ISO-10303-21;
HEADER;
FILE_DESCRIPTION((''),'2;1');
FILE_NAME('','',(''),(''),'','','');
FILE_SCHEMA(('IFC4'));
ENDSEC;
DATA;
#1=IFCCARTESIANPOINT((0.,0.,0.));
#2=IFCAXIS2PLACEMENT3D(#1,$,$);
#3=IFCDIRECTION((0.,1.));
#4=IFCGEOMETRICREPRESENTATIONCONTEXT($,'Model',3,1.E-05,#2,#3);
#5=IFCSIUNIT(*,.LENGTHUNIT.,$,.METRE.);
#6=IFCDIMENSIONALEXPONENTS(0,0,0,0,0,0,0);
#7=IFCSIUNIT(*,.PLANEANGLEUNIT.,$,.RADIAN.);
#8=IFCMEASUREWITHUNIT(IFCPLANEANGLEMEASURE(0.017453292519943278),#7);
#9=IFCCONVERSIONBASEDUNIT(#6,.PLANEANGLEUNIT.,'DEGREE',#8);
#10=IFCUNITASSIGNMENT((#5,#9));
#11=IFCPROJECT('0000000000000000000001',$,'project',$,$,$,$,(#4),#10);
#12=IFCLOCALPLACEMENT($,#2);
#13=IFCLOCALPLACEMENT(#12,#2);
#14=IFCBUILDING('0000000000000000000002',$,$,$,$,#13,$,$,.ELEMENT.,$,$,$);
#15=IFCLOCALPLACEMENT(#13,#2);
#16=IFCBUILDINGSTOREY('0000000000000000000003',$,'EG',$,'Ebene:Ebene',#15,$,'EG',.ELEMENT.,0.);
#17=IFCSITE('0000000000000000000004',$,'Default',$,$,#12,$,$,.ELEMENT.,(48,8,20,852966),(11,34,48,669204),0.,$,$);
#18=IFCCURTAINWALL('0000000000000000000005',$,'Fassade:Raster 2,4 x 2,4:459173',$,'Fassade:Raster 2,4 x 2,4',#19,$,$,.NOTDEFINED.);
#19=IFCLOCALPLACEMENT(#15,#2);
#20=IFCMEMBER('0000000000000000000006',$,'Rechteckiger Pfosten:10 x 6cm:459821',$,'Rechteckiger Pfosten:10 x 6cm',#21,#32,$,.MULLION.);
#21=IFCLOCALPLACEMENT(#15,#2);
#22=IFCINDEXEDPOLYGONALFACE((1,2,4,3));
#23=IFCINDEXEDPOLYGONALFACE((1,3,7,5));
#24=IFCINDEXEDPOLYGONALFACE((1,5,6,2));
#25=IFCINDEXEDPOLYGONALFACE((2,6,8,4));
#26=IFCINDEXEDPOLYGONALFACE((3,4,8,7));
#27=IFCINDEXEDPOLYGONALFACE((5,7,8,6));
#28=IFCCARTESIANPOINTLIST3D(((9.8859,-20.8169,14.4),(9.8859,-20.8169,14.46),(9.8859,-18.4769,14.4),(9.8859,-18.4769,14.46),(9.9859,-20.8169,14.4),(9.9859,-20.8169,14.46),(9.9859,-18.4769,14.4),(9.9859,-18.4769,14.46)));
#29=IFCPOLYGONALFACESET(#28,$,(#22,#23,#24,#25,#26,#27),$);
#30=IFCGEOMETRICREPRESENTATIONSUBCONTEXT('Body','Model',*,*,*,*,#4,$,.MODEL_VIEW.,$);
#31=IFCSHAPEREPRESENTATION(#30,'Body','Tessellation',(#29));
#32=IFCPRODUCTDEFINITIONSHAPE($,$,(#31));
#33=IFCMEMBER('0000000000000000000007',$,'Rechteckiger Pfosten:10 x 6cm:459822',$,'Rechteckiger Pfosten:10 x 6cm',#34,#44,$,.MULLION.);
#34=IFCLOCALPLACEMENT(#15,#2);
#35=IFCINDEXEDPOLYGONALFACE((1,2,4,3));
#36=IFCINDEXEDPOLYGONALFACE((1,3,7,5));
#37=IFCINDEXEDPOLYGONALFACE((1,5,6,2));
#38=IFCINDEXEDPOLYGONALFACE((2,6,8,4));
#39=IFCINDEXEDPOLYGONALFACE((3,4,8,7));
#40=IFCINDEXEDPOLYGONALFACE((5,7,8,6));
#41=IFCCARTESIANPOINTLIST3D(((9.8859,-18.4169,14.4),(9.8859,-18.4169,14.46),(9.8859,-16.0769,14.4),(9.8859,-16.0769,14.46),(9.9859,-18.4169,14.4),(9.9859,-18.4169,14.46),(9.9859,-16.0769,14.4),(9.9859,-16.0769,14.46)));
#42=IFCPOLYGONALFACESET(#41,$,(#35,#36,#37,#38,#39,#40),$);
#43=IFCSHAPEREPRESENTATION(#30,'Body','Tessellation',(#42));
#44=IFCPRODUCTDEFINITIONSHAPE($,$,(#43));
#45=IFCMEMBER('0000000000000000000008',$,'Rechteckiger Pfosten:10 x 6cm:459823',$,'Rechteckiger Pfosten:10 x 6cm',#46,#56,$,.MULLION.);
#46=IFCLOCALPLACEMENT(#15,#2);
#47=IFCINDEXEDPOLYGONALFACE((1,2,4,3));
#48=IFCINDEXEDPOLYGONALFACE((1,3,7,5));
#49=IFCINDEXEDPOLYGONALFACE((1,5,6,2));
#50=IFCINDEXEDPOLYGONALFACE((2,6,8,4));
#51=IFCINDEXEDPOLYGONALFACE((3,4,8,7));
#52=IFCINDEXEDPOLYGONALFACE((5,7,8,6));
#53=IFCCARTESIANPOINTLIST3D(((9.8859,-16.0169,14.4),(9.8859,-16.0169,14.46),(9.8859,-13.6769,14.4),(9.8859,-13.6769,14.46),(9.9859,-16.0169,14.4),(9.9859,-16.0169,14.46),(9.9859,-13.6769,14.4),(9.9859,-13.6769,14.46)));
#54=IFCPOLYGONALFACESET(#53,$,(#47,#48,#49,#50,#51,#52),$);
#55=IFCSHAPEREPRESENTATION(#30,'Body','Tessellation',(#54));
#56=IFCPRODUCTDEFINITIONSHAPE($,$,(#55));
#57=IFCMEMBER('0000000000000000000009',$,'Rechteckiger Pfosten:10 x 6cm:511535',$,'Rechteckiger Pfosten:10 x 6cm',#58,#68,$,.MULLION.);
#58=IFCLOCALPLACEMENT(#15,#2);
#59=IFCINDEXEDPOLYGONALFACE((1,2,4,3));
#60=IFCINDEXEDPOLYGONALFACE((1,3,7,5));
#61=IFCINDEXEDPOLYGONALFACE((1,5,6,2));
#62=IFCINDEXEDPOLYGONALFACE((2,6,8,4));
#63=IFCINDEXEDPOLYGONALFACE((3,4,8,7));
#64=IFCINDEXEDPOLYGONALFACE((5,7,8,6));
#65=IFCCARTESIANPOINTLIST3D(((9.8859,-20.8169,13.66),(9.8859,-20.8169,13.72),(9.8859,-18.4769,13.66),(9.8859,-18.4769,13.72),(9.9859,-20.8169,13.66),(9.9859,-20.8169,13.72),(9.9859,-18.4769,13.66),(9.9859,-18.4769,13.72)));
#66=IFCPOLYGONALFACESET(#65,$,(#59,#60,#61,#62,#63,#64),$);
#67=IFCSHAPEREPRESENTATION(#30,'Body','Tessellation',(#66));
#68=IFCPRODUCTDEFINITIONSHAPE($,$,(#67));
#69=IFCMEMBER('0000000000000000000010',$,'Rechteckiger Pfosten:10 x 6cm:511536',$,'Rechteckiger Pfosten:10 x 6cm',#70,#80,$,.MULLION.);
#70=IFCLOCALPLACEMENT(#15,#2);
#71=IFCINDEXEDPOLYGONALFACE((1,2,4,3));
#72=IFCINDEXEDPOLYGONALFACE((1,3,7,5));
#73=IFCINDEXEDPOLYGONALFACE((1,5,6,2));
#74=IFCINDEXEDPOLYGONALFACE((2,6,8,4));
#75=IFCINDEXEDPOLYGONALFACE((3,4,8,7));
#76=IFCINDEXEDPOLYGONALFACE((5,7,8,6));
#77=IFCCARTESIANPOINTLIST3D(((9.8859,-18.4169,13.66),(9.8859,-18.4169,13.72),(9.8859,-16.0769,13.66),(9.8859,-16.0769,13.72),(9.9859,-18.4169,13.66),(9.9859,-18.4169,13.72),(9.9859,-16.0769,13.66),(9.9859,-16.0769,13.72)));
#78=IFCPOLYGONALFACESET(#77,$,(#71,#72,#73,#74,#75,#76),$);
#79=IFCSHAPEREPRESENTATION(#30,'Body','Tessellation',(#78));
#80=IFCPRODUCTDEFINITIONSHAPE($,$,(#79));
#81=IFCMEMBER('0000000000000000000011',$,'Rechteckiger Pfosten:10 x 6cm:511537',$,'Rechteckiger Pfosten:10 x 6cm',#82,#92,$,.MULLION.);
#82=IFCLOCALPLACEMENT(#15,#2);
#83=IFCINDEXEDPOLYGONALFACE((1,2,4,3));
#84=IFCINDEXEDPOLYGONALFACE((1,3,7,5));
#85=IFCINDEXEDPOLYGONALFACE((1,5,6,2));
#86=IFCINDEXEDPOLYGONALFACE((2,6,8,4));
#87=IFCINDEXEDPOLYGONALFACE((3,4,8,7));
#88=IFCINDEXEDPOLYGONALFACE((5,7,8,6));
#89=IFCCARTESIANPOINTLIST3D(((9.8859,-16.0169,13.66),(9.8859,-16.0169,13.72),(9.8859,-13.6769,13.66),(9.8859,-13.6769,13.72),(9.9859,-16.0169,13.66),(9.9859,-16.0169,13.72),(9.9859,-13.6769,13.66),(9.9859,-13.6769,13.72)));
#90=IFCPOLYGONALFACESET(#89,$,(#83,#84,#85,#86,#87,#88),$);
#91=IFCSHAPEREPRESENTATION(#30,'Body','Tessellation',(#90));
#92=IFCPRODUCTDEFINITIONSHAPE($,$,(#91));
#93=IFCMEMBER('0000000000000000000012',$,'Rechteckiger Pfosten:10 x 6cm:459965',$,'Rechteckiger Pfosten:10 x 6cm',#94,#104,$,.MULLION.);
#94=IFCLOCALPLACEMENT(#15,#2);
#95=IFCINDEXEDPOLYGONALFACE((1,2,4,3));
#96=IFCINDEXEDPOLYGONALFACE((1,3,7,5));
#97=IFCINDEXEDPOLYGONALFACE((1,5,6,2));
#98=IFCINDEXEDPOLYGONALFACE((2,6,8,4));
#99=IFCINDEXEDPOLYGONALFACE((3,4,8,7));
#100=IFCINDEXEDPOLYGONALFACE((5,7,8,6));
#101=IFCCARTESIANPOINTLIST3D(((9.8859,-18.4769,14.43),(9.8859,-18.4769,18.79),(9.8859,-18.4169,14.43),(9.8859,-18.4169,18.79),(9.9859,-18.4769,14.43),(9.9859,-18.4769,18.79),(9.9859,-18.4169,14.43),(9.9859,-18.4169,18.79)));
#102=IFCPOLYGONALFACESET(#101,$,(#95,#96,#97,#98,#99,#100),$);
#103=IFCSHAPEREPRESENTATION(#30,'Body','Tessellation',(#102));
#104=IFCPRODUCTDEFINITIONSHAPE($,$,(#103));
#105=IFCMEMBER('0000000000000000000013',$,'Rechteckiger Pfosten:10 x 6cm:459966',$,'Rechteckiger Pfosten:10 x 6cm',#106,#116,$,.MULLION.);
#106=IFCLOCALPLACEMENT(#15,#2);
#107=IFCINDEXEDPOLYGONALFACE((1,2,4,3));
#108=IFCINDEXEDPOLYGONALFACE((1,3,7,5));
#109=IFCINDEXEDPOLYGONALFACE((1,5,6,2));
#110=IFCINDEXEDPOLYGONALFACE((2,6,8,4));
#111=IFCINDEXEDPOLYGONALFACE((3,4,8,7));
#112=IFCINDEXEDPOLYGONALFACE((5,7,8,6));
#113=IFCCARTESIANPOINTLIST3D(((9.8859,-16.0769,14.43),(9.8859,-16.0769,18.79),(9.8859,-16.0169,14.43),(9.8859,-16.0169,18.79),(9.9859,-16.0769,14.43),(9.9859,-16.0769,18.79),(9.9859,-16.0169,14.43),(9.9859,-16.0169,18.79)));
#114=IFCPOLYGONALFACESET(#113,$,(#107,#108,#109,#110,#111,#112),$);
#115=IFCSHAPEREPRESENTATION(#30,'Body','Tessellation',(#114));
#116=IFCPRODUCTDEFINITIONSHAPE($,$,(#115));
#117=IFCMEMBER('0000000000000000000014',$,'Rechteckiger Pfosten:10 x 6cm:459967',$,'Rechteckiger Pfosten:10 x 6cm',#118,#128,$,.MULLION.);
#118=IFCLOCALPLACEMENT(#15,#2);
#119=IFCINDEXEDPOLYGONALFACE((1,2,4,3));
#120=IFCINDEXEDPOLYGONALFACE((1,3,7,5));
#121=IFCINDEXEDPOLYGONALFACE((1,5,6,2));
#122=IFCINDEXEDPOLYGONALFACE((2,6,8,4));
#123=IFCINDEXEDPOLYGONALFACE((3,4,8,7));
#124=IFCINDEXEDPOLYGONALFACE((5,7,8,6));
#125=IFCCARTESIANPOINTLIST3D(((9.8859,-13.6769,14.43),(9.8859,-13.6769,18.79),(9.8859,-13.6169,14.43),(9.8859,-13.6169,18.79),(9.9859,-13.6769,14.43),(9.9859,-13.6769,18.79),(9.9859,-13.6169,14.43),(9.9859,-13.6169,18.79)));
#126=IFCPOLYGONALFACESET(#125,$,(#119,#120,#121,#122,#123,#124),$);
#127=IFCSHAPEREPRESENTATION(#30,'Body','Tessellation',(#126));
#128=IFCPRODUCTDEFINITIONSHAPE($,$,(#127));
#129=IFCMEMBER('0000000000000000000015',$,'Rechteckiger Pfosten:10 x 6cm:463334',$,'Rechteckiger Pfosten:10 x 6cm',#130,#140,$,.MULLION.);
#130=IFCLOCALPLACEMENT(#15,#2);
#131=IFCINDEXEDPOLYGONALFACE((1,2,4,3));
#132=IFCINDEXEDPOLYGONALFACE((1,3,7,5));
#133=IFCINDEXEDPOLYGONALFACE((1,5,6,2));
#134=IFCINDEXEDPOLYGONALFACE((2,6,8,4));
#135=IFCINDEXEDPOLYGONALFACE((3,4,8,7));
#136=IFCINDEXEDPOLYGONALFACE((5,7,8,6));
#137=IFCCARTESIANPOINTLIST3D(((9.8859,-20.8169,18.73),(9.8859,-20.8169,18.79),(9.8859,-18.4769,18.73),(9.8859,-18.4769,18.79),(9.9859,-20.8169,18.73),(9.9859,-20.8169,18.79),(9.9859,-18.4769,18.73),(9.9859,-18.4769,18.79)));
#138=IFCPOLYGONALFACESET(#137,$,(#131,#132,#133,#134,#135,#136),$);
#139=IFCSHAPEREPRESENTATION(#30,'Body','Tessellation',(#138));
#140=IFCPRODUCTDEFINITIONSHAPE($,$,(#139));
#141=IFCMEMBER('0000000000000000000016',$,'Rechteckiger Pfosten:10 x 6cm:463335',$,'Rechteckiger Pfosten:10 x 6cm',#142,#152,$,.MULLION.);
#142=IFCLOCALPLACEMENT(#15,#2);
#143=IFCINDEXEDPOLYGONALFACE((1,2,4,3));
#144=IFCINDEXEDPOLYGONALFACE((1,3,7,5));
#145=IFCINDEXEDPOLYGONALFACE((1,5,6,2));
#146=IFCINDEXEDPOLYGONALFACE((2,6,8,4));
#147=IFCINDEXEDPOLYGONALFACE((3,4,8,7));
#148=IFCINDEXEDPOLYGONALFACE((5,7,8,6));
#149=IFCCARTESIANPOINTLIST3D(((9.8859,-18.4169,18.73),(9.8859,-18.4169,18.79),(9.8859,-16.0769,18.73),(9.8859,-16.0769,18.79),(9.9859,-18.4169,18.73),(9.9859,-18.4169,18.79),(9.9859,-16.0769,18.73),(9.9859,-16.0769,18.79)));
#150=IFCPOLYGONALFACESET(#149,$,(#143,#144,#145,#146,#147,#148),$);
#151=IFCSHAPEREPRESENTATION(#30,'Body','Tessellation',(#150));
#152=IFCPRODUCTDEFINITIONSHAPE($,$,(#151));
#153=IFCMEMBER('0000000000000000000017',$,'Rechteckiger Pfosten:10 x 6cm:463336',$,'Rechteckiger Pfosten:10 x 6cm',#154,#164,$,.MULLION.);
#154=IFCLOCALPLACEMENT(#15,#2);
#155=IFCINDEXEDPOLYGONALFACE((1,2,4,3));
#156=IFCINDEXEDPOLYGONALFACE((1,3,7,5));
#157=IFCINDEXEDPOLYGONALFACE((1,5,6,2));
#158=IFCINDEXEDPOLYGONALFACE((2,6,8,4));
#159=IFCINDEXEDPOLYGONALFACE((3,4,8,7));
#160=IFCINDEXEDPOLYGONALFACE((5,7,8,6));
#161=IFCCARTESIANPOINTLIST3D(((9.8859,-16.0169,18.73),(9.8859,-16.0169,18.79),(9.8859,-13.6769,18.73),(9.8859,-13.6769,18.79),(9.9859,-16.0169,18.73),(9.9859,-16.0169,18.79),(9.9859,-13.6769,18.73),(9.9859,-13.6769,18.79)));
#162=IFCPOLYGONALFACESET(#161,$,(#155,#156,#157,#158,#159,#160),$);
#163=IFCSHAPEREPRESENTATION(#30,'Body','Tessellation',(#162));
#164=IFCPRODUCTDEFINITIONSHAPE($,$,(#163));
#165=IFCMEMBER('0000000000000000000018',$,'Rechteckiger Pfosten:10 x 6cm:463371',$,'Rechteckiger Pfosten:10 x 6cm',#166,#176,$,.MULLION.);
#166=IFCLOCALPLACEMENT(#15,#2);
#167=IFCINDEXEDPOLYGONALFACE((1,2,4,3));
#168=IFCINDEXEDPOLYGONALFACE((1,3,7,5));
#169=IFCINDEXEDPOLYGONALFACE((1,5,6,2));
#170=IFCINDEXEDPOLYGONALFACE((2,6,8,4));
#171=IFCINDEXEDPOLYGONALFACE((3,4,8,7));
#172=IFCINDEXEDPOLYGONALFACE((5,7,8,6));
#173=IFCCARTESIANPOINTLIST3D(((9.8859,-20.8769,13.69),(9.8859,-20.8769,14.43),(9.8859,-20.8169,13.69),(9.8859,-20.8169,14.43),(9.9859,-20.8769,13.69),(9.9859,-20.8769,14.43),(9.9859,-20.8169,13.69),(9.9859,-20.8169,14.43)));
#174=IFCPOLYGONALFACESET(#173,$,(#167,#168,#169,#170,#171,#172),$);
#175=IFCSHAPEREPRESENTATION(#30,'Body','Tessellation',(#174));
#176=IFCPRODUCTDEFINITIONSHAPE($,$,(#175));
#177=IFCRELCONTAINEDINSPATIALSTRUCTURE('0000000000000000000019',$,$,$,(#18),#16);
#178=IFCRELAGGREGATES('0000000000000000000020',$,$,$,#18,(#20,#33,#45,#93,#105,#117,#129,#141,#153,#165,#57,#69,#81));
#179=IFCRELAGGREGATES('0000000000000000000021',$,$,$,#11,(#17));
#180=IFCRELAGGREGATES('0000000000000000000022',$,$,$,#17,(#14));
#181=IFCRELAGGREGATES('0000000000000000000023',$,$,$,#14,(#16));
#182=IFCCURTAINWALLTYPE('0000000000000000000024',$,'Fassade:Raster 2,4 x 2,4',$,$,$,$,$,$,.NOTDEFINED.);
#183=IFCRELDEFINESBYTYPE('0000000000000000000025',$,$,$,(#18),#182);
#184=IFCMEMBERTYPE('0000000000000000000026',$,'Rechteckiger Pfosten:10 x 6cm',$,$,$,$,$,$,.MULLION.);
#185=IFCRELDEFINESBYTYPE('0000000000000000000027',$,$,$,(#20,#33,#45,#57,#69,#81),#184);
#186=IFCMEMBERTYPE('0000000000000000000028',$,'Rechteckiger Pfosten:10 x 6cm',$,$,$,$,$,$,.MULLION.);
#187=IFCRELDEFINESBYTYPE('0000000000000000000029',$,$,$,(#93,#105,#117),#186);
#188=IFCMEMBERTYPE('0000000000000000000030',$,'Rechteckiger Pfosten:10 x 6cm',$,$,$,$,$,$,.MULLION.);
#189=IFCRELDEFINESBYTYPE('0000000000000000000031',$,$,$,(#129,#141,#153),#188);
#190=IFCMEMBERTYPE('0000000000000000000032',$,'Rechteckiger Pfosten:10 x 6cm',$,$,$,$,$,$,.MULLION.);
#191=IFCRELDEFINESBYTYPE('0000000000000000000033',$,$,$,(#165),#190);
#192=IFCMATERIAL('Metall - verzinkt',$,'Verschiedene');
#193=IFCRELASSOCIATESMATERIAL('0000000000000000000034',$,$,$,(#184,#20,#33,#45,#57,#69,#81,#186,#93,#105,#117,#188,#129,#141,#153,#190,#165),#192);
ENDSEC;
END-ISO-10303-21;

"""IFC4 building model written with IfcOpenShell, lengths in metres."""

from ifc_helpers import new_model, entity, si_unit, converted_unit, direction, frame, origin, place, context, subcontext, project, spatial, indexed_curve, outline, extrude, source, transform, mapped, material, type_object, type_shapes, element, aggregate, save


model = new_model("IFC4")

# Units and contexts
model_context = context("Model", 3, precision=1e-05, world=origin(), true_north=direction((0.0, 1.0)))
body_context = subcontext(model_context, "Body", "Model", "MODEL_VIEW")
ifc_project = project(units=[si_unit("LENGTHUNIT", "METRE"), converted_unit("PLANEANGLEUNIT", "DEGREE", entity("IfcPlaneAngleMeasure", 0.017453292519943278), si_unit("PLANEANGLEUNIT", "RADIAN"), dimensions=[0, 0, 0, 0, 0, 0, 0])], contexts=[model_context])

# Site, building, storey
site_placement = place(None, origin())
site = spatial("IfcSite", under=ifc_project, at=site_placement, Name="Default", CompositionType="ELEMENT", RefLatitude=(48, 8, 20, 852966), RefLongitude=(11, 34, 48, 669204), RefElevation=0.0)
building_placement = place(site_placement, origin())
building = spatial("IfcBuilding", under=site, at=building_placement, CompositionType="ELEMENT")
storey_placement = place(building_placement, origin())
storey = spatial("IfcBuildingStorey", under=building, at=storey_placement, Name="EG", ObjectType="Ebene:Ebene", LongName="EG", CompositionType="ELEMENT", Elevation=0.0)

# Curtain wall, members
curtain_wall_type = type_object("IfcCurtainWallType", Name="Fassade:Raster 2,4 x 2,4", PredefinedType="NOTDEFINED")
curtain_wall_placement = place(storey_placement, origin())
curtain_wall = element("IfcCurtainWall", 1, at=curtain_wall_placement, inside=storey, type_object=curtain_wall_type, Name="Fassade:Raster 2,4 x 2,4:459173", ObjectType="Fassade:Raster 2,4 x 2,4", PredefinedType="NOTDEFINED")
ifc_material_1 = material(Name="Metall - verzinkt", Category="Verschiedene")
member_type_1 = type_object("IfcMemberType", Name="Rechteckiger Pfosten:10 x 6cm", PredefinedType="MULLION", material=ifc_material_1)
shared_shape_1 = source(origin(), body_context, "Body", "SweptSolid", [
    extrude(outline(indexed_curve([(-0.03, -0.05), (0.03, -0.05), (0.03, 0.05), (-0.03, 0.05), (-0.03, -0.05)], self_intersect=False)), frame((0.0, 0.0, -2.34), z_axis=(0.0, 0.0, 1.0), x_axis=(-1.0, 0.0, 0.0)), (0.0, 0.0, 1.0), 2.34),
])
type_shapes(member_type_1, [shared_shape_1])
member_1_placement = place(curtain_wall_placement, frame((9.9359, -18.4769, 14.43), z_axis=(0.0, 1.0, 0.0), x_axis=(0.0, 0.0, 1.0)))
member_1 = element("IfcMember", 2, at=member_1_placement, type_object=member_type_1, material=ifc_material_1, Name="Rechteckiger Pfosten:10 x 6cm:459821", ObjectType="Rechteckiger Pfosten:10 x 6cm", PredefinedType="MULLION", context=body_context, shape_type="MappedRepresentation", body=[
    mapped(shared_shape_1, transform((0.0, 0.0, 0.0), scale=1.0)),
])
member_2_placement = place(curtain_wall_placement, frame((9.9359, -16.0769, 14.43), z_axis=(0.0, 1.0, 0.0), x_axis=(0.0, 0.0, 1.0)))
member_2 = element("IfcMember", 3, at=member_2_placement, type_object=member_type_1, material=ifc_material_1, Name="Rechteckiger Pfosten:10 x 6cm:459822", ObjectType="Rechteckiger Pfosten:10 x 6cm", PredefinedType="MULLION", context=body_context, shape_type="MappedRepresentation", body=[
    mapped(shared_shape_1, transform((0.0, 0.0, 0.0), scale=1.0)),
])
member_3_placement = place(curtain_wall_placement, frame((9.9359, -13.6769, 14.43), z_axis=(0.0, 1.0, 0.0), x_axis=(0.0, 0.0, 1.0)))
member_3 = element("IfcMember", 4, at=member_3_placement, type_object=member_type_1, material=ifc_material_1, Name="Rechteckiger Pfosten:10 x 6cm:459823", ObjectType="Rechteckiger Pfosten:10 x 6cm", PredefinedType="MULLION", context=body_context, shape_type="MappedRepresentation", body=[
    mapped(shared_shape_1, transform((0.0, 0.0, 0.0), scale=1.0)),
])
member_4_placement = place(curtain_wall_placement, frame((9.9359, -18.4769, 13.69), z_axis=(0.0, 1.0, 0.0), x_axis=(0.0, 0.0, 1.0)))
member_4 = element("IfcMember", 5, at=member_4_placement, type_object=member_type_1, material=ifc_material_1, Name="Rechteckiger Pfosten:10 x 6cm:511535", ObjectType="Rechteckiger Pfosten:10 x 6cm", PredefinedType="MULLION", context=body_context, shape_type="MappedRepresentation", body=[
    mapped(shared_shape_1, transform((0.0, 0.0, 0.0), scale=1.0)),
])
member_5_placement = place(curtain_wall_placement, frame((9.9359, -16.0769, 13.69), z_axis=(0.0, 1.0, 0.0), x_axis=(0.0, 0.0, 1.0)))
member_5 = element("IfcMember", 6, at=member_5_placement, type_object=member_type_1, material=ifc_material_1, Name="Rechteckiger Pfosten:10 x 6cm:511536", ObjectType="Rechteckiger Pfosten:10 x 6cm", PredefinedType="MULLION", context=body_context, shape_type="MappedRepresentation", body=[
    mapped(shared_shape_1, transform((0.0, 0.0, 0.0), scale=1.0)),
])
member_6_placement = place(curtain_wall_placement, frame((9.9359, -13.6769, 13.69), z_axis=(0.0, 1.0, 0.0), x_axis=(0.0, 0.0, 1.0)))
member_6 = element("IfcMember", 7, at=member_6_placement, type_object=member_type_1, material=ifc_material_1, Name="Rechteckiger Pfosten:10 x 6cm:511537", ObjectType="Rechteckiger Pfosten:10 x 6cm", PredefinedType="MULLION", context=body_context, shape_type="MappedRepresentation", body=[
    mapped(shared_shape_1, transform((0.0, 0.0, 0.0), scale=1.0)),
])
member_type_2 = type_object("IfcMemberType", Name="Rechteckiger Pfosten:10 x 6cm", PredefinedType="MULLION", material=ifc_material_1)
shared_shape_2 = source(origin(), body_context, "Body", "SweptSolid", [
    extrude(outline(indexed_curve([(-0.03, -0.05), (0.03, -0.05), (0.03, 0.05), (-0.03, 0.05), (-0.03, -0.05)], self_intersect=False)), frame((0.0, 0.0, -4.36), z_axis=(0.0, 0.0, 1.0), x_axis=(-1.0, 0.0, 0.0)), (0.0, 0.0, 1.0), 4.36),
])
type_shapes(member_type_2, [shared_shape_2])
member_7_placement = place(curtain_wall_placement, frame((9.9359, -18.4469, 14.43), z_axis=(0.0, 0.0, -1.0), x_axis=(0.0, 1.0, 0.0)))
member_7 = element("IfcMember", 8, at=member_7_placement, type_object=member_type_2, material=ifc_material_1, Name="Rechteckiger Pfosten:10 x 6cm:459965", ObjectType="Rechteckiger Pfosten:10 x 6cm", PredefinedType="MULLION", context=body_context, shape_type="MappedRepresentation", body=[
    mapped(shared_shape_2, transform((0.0, 0.0, 0.0), scale=1.0)),
])
member_8_placement = place(curtain_wall_placement, frame((9.9359, -16.0469, 14.43), z_axis=(0.0, 0.0, -1.0), x_axis=(0.0, 1.0, 0.0)))
member_8 = element("IfcMember", 9, at=member_8_placement, type_object=member_type_2, material=ifc_material_1, Name="Rechteckiger Pfosten:10 x 6cm:459966", ObjectType="Rechteckiger Pfosten:10 x 6cm", PredefinedType="MULLION", context=body_context, shape_type="MappedRepresentation", body=[
    mapped(shared_shape_2, transform((0.0, 0.0, 0.0), scale=1.0)),
])
member_9_placement = place(curtain_wall_placement, frame((9.9359, -13.6469, 14.43), z_axis=(0.0, 0.0, -1.0), x_axis=(0.0, 1.0, 0.0)))
member_9 = element("IfcMember", 10, at=member_9_placement, type_object=member_type_2, material=ifc_material_1, Name="Rechteckiger Pfosten:10 x 6cm:459967", ObjectType="Rechteckiger Pfosten:10 x 6cm", PredefinedType="MULLION", context=body_context, shape_type="MappedRepresentation", body=[
    mapped(shared_shape_2, transform((0.0, 0.0, 0.0), scale=1.0)),
])
member_type_3 = type_object("IfcMemberType", Name="Rechteckiger Pfosten:10 x 6cm", PredefinedType="MULLION", material=ifc_material_1)
shared_shape_3 = source(origin(), body_context, "Body", "SweptSolid", [
    extrude(outline(indexed_curve([(-0.03, -0.05), (0.03, -0.05), (0.03, 0.05), (-0.03, 0.05), (-0.03, -0.05)], self_intersect=False)), frame((-0.03, 0.0, -2.34), z_axis=(0.0, 0.0, 1.0), x_axis=(-1.0, 0.0, 0.0)), (0.0, 0.0, 1.0), 2.34),
])
type_shapes(member_type_3, [shared_shape_3])
member_10_placement = place(curtain_wall_placement, frame((9.9359, -18.4769, 18.79), z_axis=(0.0, 1.0, 0.0), x_axis=(0.0, 0.0, 1.0)))
member_10 = element("IfcMember", 11, at=member_10_placement, type_object=member_type_3, material=ifc_material_1, Name="Rechteckiger Pfosten:10 x 6cm:463334", ObjectType="Rechteckiger Pfosten:10 x 6cm", PredefinedType="MULLION", context=body_context, shape_type="MappedRepresentation", body=[
    mapped(shared_shape_3, transform((0.0, 0.0, 0.0), scale=1.0)),
])
member_11_placement = place(curtain_wall_placement, frame((9.9359, -16.0769, 18.79), z_axis=(0.0, 1.0, 0.0), x_axis=(0.0, 0.0, 1.0)))
member_11 = element("IfcMember", 12, at=member_11_placement, type_object=member_type_3, material=ifc_material_1, Name="Rechteckiger Pfosten:10 x 6cm:463335", ObjectType="Rechteckiger Pfosten:10 x 6cm", PredefinedType="MULLION", context=body_context, shape_type="MappedRepresentation", body=[
    mapped(shared_shape_3, transform((0.0, 0.0, 0.0), scale=1.0)),
])
member_12_placement = place(curtain_wall_placement, frame((9.9359, -13.6769, 18.79), z_axis=(0.0, 1.0, 0.0), x_axis=(0.0, 0.0, 1.0)))
member_12 = element("IfcMember", 13, at=member_12_placement, type_object=member_type_3, material=ifc_material_1, Name="Rechteckiger Pfosten:10 x 6cm:463336", ObjectType="Rechteckiger Pfosten:10 x 6cm", PredefinedType="MULLION", context=body_context, shape_type="MappedRepresentation", body=[
    mapped(shared_shape_3, transform((0.0, 0.0, 0.0), scale=1.0)),
])
member_type_4 = type_object("IfcMemberType", Name="Rechteckiger Pfosten:10 x 6cm", PredefinedType="MULLION", material=ifc_material_1)
shared_shape_4 = source(origin(), body_context, "Body", "SweptSolid", [
    extrude(outline(indexed_curve([(-0.03, -0.05), (0.03, -0.05), (0.03, 0.05), (-0.03, 0.05), (-0.03, -0.05)], self_intersect=False)), frame((-0.03, 0.0, -0.74), z_axis=(0.0, 0.0, 1.0), x_axis=(-1.0, 0.0, 0.0)), (0.0, 0.0, 1.0), 0.74),
])
type_shapes(member_type_4, [shared_shape_4])
member_13_placement = place(curtain_wall_placement, frame((9.9359, -20.8769, 14.43), z_axis=(0.0, 0.0, 1.0), x_axis=(0.0, -1.0, 0.0)))
member_13 = element("IfcMember", 14, at=member_13_placement, type_object=member_type_4, material=ifc_material_1, Name="Rechteckiger Pfosten:10 x 6cm:463371", ObjectType="Rechteckiger Pfosten:10 x 6cm", PredefinedType="MULLION", context=body_context, shape_type="MappedRepresentation", body=[
    mapped(shared_shape_4, transform((0.0, 0.0, 0.0), scale=1.0)),
])
aggregate(curtain_wall, [member_1, member_2, member_3, member_7, member_8, member_9, member_10, member_11, member_12, member_13, member_4, member_5, member_6])

save(model, "model.ifc")
